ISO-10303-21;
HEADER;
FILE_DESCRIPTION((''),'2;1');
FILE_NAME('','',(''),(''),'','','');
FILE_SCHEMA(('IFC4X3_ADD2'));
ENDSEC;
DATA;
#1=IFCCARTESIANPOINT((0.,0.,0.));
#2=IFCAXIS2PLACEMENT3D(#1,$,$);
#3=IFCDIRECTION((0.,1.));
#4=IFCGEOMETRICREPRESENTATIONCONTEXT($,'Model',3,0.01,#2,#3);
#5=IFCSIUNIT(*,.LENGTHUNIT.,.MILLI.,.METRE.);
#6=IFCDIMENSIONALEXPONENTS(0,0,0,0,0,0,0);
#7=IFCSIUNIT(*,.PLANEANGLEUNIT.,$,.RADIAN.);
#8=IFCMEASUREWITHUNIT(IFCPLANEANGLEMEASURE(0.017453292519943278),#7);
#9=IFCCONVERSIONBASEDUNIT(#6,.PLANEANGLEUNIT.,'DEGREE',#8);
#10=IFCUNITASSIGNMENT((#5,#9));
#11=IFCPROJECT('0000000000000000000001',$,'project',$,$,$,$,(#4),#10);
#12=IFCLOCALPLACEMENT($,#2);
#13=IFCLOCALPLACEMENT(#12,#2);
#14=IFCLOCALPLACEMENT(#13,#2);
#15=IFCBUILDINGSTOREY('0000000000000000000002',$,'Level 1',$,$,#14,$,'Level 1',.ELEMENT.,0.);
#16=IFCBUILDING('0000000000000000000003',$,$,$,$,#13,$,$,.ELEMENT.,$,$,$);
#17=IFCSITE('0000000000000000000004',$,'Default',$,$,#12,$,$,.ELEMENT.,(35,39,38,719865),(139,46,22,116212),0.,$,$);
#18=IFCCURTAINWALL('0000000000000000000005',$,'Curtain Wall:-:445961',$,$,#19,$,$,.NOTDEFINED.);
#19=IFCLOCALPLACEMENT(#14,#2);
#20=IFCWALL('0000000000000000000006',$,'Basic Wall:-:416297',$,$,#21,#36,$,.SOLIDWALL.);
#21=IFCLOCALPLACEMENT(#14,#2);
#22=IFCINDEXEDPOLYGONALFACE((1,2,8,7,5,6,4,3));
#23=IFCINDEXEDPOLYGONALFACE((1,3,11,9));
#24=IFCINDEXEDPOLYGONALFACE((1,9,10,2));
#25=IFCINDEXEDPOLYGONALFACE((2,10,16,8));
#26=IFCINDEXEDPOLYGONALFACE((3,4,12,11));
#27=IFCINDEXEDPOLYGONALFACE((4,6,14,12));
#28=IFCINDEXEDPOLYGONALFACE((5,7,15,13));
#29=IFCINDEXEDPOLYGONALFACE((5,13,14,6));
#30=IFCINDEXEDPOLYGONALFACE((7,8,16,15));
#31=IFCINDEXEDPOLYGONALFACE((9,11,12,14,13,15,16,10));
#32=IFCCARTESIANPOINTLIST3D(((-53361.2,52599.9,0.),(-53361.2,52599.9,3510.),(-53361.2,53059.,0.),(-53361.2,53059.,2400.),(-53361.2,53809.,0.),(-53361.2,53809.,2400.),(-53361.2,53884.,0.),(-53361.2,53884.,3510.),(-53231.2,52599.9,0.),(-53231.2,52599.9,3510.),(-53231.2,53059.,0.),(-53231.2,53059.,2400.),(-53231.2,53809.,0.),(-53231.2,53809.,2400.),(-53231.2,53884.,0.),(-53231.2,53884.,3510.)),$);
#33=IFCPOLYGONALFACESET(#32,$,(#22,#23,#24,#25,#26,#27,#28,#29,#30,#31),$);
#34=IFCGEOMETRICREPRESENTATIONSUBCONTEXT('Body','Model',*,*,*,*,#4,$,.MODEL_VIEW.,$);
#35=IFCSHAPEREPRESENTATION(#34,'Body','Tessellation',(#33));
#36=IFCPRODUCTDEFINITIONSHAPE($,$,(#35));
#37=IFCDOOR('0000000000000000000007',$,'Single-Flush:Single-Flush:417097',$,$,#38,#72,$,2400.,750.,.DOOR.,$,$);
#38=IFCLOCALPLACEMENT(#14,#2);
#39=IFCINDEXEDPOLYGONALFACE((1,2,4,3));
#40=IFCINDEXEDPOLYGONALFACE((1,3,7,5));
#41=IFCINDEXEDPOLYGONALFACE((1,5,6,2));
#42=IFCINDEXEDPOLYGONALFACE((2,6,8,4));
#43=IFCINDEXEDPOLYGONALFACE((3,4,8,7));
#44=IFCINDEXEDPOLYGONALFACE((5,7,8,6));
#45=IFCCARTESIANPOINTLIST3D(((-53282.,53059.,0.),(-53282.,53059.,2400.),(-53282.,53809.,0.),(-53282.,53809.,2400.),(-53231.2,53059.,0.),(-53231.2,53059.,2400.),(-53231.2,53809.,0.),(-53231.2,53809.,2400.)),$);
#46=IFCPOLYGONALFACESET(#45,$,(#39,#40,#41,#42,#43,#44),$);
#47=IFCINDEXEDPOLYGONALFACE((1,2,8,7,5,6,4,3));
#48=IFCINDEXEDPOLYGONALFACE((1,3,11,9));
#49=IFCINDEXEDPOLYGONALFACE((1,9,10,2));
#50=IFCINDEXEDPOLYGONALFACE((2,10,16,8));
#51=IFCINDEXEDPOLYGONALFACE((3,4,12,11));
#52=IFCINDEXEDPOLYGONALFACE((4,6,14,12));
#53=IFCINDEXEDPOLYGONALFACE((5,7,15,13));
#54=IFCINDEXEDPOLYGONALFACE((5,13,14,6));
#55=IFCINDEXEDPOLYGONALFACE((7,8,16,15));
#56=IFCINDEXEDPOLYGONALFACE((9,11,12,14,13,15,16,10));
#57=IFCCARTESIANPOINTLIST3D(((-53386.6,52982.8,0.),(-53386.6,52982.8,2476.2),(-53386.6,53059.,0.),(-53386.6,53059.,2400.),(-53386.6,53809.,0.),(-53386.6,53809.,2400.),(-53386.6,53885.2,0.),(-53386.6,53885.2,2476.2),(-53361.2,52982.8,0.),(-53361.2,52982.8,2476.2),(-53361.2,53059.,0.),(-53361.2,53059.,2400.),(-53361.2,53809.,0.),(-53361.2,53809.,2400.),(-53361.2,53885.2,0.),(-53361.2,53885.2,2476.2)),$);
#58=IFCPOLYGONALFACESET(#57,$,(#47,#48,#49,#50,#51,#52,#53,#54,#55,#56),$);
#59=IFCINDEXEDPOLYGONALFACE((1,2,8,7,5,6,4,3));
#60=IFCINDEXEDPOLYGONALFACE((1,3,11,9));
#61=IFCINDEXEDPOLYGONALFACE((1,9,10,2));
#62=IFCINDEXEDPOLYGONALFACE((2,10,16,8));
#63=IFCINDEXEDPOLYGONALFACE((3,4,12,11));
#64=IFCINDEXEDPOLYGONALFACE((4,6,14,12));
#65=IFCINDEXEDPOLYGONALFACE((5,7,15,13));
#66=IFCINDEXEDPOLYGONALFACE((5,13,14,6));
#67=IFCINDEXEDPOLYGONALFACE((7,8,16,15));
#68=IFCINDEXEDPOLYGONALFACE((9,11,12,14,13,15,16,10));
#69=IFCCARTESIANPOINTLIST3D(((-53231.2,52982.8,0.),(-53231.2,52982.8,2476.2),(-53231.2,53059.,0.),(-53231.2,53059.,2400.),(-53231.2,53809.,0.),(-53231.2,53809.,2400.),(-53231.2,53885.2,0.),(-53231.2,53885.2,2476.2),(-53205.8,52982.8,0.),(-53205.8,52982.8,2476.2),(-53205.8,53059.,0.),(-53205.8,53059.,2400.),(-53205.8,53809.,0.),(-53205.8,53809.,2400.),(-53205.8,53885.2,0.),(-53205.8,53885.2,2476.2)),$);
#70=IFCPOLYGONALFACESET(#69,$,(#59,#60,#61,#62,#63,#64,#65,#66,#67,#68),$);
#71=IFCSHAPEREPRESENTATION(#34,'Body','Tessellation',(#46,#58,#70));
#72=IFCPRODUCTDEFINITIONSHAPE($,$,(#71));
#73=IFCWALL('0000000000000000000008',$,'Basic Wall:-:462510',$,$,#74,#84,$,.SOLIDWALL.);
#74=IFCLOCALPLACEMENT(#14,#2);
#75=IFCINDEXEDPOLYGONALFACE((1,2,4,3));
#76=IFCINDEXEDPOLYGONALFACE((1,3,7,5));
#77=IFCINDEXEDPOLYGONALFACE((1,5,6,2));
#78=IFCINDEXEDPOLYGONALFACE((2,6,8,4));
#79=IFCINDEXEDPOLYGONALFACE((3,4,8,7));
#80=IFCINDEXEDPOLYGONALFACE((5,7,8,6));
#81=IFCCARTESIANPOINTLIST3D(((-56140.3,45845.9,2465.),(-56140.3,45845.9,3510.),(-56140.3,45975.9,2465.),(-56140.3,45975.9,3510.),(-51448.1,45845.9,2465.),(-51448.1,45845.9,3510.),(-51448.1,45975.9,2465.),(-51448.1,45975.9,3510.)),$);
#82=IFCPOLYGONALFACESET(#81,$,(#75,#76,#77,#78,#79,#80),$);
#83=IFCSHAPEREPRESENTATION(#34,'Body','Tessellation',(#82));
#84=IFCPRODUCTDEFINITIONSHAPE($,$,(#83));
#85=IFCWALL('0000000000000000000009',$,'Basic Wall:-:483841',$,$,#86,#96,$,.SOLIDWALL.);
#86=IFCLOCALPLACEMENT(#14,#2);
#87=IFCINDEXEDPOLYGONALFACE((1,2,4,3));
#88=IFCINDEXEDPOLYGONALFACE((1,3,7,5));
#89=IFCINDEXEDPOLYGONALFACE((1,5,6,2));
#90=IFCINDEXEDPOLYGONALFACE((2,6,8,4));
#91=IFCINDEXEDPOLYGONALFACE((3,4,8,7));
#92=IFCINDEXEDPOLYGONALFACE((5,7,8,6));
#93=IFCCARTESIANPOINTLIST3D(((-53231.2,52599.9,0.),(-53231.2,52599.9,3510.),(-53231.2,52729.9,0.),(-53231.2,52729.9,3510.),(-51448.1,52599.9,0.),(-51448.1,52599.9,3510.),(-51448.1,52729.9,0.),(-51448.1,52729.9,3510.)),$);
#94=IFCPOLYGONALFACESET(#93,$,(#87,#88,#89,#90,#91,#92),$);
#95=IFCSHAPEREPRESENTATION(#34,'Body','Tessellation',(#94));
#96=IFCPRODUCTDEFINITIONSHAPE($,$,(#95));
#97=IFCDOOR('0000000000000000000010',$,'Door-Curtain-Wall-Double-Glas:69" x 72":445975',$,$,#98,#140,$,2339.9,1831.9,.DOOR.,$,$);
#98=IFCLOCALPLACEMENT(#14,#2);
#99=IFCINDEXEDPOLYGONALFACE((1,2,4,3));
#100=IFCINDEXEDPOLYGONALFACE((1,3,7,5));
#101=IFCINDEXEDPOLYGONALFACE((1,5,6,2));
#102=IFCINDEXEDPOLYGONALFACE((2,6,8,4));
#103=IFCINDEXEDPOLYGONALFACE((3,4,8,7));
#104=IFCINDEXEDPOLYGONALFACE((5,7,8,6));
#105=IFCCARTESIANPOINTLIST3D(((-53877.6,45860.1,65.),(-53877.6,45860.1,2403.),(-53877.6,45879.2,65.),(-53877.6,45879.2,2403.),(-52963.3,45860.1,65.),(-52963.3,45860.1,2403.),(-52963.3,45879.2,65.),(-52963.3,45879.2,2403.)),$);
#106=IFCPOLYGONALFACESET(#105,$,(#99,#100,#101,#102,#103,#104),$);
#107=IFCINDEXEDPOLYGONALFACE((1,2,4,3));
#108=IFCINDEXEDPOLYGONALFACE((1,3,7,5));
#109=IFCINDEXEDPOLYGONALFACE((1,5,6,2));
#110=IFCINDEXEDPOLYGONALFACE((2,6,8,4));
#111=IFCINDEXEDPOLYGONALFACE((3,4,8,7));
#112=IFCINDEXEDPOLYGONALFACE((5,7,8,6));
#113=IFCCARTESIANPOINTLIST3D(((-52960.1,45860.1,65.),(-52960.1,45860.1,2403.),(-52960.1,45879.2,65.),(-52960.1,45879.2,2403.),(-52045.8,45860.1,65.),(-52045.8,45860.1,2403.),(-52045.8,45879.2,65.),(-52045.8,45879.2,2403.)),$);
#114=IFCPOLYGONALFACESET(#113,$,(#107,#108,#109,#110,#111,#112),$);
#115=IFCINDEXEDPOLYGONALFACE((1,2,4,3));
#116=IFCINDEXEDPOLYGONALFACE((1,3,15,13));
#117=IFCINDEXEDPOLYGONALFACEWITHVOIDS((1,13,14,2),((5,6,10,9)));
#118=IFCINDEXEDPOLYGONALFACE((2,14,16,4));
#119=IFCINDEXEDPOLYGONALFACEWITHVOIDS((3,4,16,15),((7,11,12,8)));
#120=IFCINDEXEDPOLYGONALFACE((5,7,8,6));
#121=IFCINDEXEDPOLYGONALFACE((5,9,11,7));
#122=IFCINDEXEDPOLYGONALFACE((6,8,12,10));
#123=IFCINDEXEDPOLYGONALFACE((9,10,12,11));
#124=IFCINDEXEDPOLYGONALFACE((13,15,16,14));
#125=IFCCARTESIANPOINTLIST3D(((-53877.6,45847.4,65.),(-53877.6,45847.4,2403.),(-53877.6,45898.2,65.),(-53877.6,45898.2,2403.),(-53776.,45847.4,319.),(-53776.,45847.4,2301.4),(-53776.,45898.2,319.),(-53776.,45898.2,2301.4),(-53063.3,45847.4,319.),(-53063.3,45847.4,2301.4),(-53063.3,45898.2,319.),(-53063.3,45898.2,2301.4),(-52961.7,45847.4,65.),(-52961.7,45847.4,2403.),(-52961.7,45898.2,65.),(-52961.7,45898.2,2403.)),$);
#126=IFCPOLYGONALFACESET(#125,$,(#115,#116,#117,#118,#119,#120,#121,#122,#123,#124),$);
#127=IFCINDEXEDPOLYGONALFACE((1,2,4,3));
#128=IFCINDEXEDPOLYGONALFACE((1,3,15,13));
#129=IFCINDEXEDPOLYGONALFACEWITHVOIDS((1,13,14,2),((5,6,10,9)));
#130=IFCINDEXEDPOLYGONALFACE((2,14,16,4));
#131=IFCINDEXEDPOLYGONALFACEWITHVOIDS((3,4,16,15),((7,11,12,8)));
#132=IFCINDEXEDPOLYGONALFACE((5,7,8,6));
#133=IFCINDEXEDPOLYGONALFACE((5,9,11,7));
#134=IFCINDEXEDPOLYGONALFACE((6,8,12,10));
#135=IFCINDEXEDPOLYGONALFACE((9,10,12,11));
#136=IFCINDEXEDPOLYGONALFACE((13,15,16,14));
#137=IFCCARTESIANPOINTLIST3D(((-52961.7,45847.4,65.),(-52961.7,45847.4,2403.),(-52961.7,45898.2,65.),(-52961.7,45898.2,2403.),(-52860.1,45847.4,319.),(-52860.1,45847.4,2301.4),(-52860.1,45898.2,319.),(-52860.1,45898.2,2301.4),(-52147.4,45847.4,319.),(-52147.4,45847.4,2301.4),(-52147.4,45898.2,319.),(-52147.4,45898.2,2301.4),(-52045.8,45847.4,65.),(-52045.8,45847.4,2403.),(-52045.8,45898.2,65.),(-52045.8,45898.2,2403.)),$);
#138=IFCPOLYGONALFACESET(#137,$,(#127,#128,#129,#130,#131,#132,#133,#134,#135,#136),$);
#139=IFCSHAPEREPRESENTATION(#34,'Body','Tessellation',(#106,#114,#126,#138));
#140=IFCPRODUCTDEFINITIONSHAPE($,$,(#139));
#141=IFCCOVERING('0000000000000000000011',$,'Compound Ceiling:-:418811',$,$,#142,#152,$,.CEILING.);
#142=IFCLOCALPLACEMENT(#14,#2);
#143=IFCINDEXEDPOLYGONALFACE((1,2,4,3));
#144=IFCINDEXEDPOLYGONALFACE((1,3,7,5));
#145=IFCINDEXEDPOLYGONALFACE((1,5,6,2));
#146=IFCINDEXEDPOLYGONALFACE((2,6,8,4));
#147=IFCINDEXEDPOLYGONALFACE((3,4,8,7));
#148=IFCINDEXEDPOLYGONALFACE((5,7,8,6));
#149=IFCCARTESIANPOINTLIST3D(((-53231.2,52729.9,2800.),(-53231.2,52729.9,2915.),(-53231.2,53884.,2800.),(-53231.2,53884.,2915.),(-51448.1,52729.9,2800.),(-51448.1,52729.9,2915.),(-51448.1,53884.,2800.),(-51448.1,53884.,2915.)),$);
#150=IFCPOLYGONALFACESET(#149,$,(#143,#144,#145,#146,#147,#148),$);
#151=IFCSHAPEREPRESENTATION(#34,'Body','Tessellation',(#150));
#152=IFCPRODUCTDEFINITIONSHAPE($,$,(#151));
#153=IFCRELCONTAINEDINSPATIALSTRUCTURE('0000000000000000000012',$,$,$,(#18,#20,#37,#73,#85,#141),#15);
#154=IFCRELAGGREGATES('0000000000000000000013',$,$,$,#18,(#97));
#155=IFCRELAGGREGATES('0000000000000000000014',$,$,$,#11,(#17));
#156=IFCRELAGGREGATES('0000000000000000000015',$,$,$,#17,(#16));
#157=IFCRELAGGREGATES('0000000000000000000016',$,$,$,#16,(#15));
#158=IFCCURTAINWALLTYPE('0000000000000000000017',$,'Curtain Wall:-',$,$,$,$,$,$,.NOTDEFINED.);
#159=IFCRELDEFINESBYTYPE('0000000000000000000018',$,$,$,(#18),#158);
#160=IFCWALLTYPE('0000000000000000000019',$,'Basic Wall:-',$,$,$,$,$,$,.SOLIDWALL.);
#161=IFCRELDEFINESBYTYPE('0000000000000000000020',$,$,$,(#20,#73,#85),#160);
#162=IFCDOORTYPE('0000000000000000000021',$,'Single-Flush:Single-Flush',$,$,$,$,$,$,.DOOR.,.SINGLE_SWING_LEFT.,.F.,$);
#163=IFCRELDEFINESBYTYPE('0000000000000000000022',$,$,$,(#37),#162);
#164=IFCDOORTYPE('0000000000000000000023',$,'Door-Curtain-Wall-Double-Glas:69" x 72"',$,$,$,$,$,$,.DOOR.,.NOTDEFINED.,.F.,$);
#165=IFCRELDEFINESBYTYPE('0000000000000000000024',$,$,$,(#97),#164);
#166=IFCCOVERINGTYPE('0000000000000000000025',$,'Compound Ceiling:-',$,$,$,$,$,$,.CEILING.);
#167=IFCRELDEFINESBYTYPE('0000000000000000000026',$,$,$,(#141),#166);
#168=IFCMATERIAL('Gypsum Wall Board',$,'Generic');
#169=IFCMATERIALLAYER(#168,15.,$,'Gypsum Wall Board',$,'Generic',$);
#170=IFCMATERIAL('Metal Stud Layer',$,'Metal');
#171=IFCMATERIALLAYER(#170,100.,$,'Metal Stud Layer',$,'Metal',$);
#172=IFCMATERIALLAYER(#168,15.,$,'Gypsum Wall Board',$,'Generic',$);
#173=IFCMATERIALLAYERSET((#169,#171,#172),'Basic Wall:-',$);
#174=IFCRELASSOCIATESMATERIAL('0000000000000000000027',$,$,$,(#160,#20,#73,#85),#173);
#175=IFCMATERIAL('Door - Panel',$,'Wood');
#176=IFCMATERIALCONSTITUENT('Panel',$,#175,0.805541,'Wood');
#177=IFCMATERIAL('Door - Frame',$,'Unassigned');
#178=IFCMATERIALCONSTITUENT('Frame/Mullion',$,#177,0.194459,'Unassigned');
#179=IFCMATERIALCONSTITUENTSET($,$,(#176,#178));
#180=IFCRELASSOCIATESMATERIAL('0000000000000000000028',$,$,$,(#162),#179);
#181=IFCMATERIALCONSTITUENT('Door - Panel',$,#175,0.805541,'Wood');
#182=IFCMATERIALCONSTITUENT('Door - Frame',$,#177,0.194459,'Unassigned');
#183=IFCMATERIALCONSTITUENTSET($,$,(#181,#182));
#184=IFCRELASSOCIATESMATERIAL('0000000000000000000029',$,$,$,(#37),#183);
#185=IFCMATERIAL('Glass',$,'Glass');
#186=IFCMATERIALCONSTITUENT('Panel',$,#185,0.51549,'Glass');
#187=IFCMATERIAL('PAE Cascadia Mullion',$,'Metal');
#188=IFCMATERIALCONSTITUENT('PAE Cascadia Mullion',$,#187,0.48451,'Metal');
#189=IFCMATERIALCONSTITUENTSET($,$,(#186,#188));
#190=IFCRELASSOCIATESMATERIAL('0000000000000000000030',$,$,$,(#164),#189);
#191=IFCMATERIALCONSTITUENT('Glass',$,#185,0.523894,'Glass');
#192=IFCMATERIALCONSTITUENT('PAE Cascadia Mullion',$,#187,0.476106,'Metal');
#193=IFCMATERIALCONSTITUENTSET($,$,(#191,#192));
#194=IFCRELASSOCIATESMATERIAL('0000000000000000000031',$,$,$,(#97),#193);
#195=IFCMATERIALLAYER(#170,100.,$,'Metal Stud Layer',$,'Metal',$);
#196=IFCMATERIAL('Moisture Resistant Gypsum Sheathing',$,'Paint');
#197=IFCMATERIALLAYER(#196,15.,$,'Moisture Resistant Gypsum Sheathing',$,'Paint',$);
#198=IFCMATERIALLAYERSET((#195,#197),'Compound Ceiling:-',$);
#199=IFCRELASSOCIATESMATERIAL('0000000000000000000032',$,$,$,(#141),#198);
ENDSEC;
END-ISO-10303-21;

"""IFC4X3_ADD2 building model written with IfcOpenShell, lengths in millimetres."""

from ifc_helpers import new_model, entity, si_unit, converted_unit, direction, frame, frame_2d, origin, place, context, subcontext, project, spatial, polyline, rectangle, outline, extrude, source, transform, mapped, material, layer, layer_set, layer_usage, constituent, constituent_set, type_object, type_shapes, element, fill, aggregate, save


model = new_model("IFC4X3_ADD2")

# Units and contexts
model_context = context("Model", 3, precision=0.01, world=origin(), true_north=direction((0.0, 1.0)))
body_context = subcontext(model_context, "Body", "Model", "MODEL_VIEW")
ifc_project = project(units=[si_unit("LENGTHUNIT", "METRE", prefix="MILLI"), converted_unit("PLANEANGLEUNIT", "DEGREE", entity("IfcPlaneAngleMeasure", 0.017453292519943278), si_unit("PLANEANGLEUNIT", "RADIAN"), dimensions=[0, 0, 0, 0, 0, 0, 0])], contexts=[model_context])

# Site, building, storey
site_placement = place(None, origin())
site = spatial("IfcSite", under=ifc_project, at=site_placement, Name="Default", CompositionType="ELEMENT", RefLatitude=(35, 39, 38, 719865), RefLongitude=(139, 46, 22, 116212), RefElevation=0.0)
building_placement = place(site_placement, origin())
building = spatial("IfcBuilding", under=site, at=building_placement, CompositionType="ELEMENT")
storey_placement = place(building_placement, origin())
storey = spatial("IfcBuildingStorey", under=building, at=storey_placement, Name="Level 1", LongName="Level 1", CompositionType="ELEMENT", Elevation=0.0)

# Curtain wall
curtain_wall_type = type_object("IfcCurtainWallType", Name="Curtain Wall:-", PredefinedType="NOTDEFINED")
curtain_wall_placement = place(storey_placement, origin())
curtain_wall = element("IfcCurtainWall", 1, at=curtain_wall_placement, inside=storey, type_object=curtain_wall_type, Name="Curtain Wall:-:445961", PredefinedType="NOTDEFINED")

# Shared definitions
ifc_material_1 = material(Name="Glass", Category="Glass")

# Shared definitions
ifc_material_2 = material(Name="Gypsum Wall Board", Category="Generic")
ifc_layer_1 = layer(ifc_material_2, 15.0, Name="Gypsum Wall Board", Category="Generic")
ifc_material_3 = material(Name="Metal Stud Layer", Category="Metal")
ifc_layer_2 = layer(ifc_material_3, 100.0, Name="Metal Stud Layer", Category="Metal")
ifc_layer_3 = layer(ifc_material_2, 15.0, Name="Gypsum Wall Board", Category="Generic")
ifc_layer_set_1 = layer_set([ifc_layer_1, ifc_layer_2, ifc_layer_3], Name="Basic Wall:-")
wall_type = type_object("IfcWallType", Name="Basic Wall:-", PredefinedType="SOLIDWALL", material=ifc_layer_set_1)

# Wall, opening, door
wall_1_placement = place(storey_placement, frame((-53296.2, 52599.9, 0.0), z_axis=(0.0, 0.0, 1.0), x_axis=(0.0, 1.0, 0.0)))
wall_1 = element("IfcWall", 2, at=wall_1_placement, inside=storey, type_object=wall_type, material=ifc_layer_set_1, Name="Basic Wall:-:416297", PredefinedType="SOLIDWALL", context=body_context, shape_type="SweptSolid", body=[
    extrude(rectangle(XDim=1284.2, YDim=130.0, at=frame_2d((642.1, 0.0), x_axis=(-1.0, 0.0))), origin(), (0.0, 0.0, 1.0), 3510.0),
])
opening_1_placement = place(wall_1_placement, frame((1209.1, 65.0, 0.0)))
opening_1 = element("IfcOpeningElement", 3, at=opening_1_placement, cuts=wall_1, PredefinedType="OPENING", context=body_context, shape_type="SweptSolid", body=[
    extrude(rectangle(XDim=750.0, YDim=2400.0, at=frame_2d((1200.0, 375.0), x_axis=(0.0, -1.0))), frame((0.0, 0.0, 0.0), z_axis=(0.0, -1.0, 0.0), x_axis=(0.0, 0.0, 1.0)), (0.0, 0.0, 1.0), 130.0),
])
ifc_material_4 = material(Name="Door - Panel", Category="Wood")
ifc_constituent_1 = constituent(ifc_material_4, Name="Door - Panel", Category="Wood", fraction=0.805541)
ifc_material_5 = material(Name="Door - Frame", Category="Unassigned")
ifc_constituent_2 = constituent(ifc_material_5, Name="Door - Frame", Category="Unassigned", fraction=0.194459)
ifc_constituent_set_1 = constituent_set(constituents=[ifc_constituent_1, ifc_constituent_2])
ifc_constituent_3 = constituent(ifc_material_4, Name="Panel", Category="Wood", fraction=0.805541)
ifc_constituent_4 = constituent(ifc_material_5, Name="Frame/Mullion", Category="Unassigned", fraction=0.194459)
ifc_constituent_set_2 = constituent_set(constituents=[ifc_constituent_3, ifc_constituent_4])
door_type_1 = type_object("IfcDoorType", Name="Single-Flush:Single-Flush", OperationType="SINGLE_SWING_LEFT", ParameterTakesPrecedence=False, PredefinedType="DOOR", material=ifc_constituent_set_2)
shared_shape_1 = source(origin(), body_context, "Body", "SweptSolid", [
    extrude(rectangle(XDim=750.0, YDim=50.8, at=frame_2d((0.0, 0.0), x_axis=(1.0, 0.0))), frame((375.0, 104.6, 0.0)), (0.0, 0.0, 1.0), 2400.0),
    extrude(outline(polyline([(-1257.1, -451.2), (1219.0, -451.2), (1219.0, -375.0), (-1180.9, -375.0), (-1180.9, 375.0), (1219.0, 375.0), (1219.0, 451.2), (-1257.1, 451.2), (-1257.1, -451.2)])), frame((375.0, 0.0, 1219.0), z_axis=(0.0, -1.0, 0.0), x_axis=(0.0, 0.0, -1.0)), (0.0, 0.0, 1.0), 25.4),
    extrude(outline(polyline([(-451.2, -1257.1), (451.2, -1257.1), (451.2, 1219.1), (375.0, 1219.1), (375.0, -1181.0), (-375.0, -1181.0), (-375.0, 1219.1), (-451.2, 1219.1), (-451.2, -1257.1)])), frame((375.0, 155.4, 1219.1), z_axis=(0.0, -1.0, 0.0), x_axis=(-1.0, 0.0, 0.0)), (0.0, 0.0, 1.0), 25.4),
])
type_shapes(door_type_1, [shared_shape_1])
door_1_placement = place(opening_1_placement, frame((0.0, 0.0, 0.0), z_axis=(0.0, 0.0, 1.0), x_axis=(-1.0, 0.0, 0.0)))
door_1 = element("IfcDoor", 4, at=door_1_placement, inside=storey, type_object=door_type_1, material=ifc_constituent_set_1, Name="Single-Flush:Single-Flush:417097", OverallHeight=2400.0, OverallWidth=750.0, PredefinedType="DOOR", context=body_context, shape_type="MappedRepresentation", body=[
    mapped(shared_shape_1, transform((0.0, 0.0, 0.0), scale=1.0)),
])
fill(opening_1, door_1)

# Walls
wall_2_placement = place(storey_placement, frame((-51448.1, 45910.9, 2465.0), z_axis=(0.0, 0.0, 1.0), x_axis=(-1.0, 0.0, 0.0)))
element("IfcWall", 5, at=wall_2_placement, inside=storey, type_object=wall_type, material=ifc_layer_set_1, Name="Basic Wall:-:462510", PredefinedType="SOLIDWALL", context=body_context, shape_type="SweptSolid", body=[
    extrude(rectangle(XDim=4692.1, YDim=130.0, at=frame_2d((2346.1, 0.0), x_axis=(-1.0, 0.0))), origin(), (0.0, 0.0, 1.0), 1045.0),
])
wall_3_placement = place(storey_placement, frame((-51448.1, 52664.9, 0.0), z_axis=(0.0, 0.0, 1.0), x_axis=(-1.0, 0.0, 0.0)))
element("IfcWall", 6, at=wall_3_placement, inside=storey, type_object=wall_type, material=ifc_layer_set_1, Name="Basic Wall:-:483841", PredefinedType="SOLIDWALL", context=body_context, shape_type="SweptSolid", body=[
    extrude(rectangle(XDim=1783.1, YDim=130.0, at=frame_2d((891.5, 0.0), x_axis=(-1.0, 0.0))), origin(), (0.0, 0.0, 1.0), 3510.0),
])

# Door
ifc_constituent_5 = constituent(ifc_material_1, Name="Glass", Category="Glass", fraction=0.523894)
ifc_material_6 = material(Name="PAE Cascadia Mullion", Category="Metal")
ifc_constituent_6 = constituent(ifc_material_6, Name="PAE Cascadia Mullion", Category="Metal", fraction=0.476106)
ifc_constituent_set_3 = constituent_set(constituents=[ifc_constituent_5, ifc_constituent_6])
ifc_constituent_7 = constituent(ifc_material_1, Name="Panel", Category="Glass", fraction=0.51549)
ifc_constituent_8 = constituent(ifc_material_6, Name="PAE Cascadia Mullion", Category="Metal", fraction=0.48451)
ifc_constituent_set_4 = constituent_set(constituents=[ifc_constituent_7, ifc_constituent_8])
door_type_2 = type_object("IfcDoorType", Name="Door-Curtain-Wall-Double-Glas:69\" x 72\"", OperationType="NOTDEFINED", ParameterTakesPrecedence=False, PredefinedType="DOOR", material=ifc_constituent_set_4)
shared_shape_2 = source(origin(), body_context, "Body", "SweptSolid", [
    extrude(rectangle(XDim=19.1, YDim=914.4, at=frame_2d((0.0, 0.0), x_axis=(1.0, 0.0))), frame((458.7, 41.3, 0.0), z_axis=(0.0, 0.0, 1.0), x_axis=(0.0, 1.0, 0.0)), (0.0, 0.0, 1.0), 2338.0),
    extrude(rectangle(XDim=19.1, YDim=914.3, at=frame_2d((0.0, 0.0), x_axis=(1.0, 0.0))), frame((-458.8, 41.3, 0.0), z_axis=(0.0, 0.0, 1.0), x_axis=(0.0, 1.0, 0.0)), (0.0, 0.0, 1.0), 2338.0),
    extrude(outline(polyline([(-458.0, -1169.0), (458.0, -1169.0), (458.0, 1169.0), (-458.0, 1169.0), (-458.0, -1169.0)]), holes=[polyline([(-356.4, -1067.4), (-356.4, 915.0), (356.4, 915.0), (356.4, -1067.4), (-356.4, -1067.4)])]), frame((458.0, 12.7, 1169.0), z_axis=(0.0, 1.0, 0.0), x_axis=(1.0, 0.0, 0.0)), (0.0, 0.0, 1.0), 50.8),
    extrude(outline(polyline([(-1169.0, -458.0), (1169.0, -458.0), (1169.0, 458.0), (-1169.0, 458.0), (-1169.0, -458.0)]), holes=[polyline([(-1067.4, -356.4), (-1067.4, 356.4), (915.0, 356.4), (915.0, -356.4), (-1067.4, -356.4)])]), frame((-458.0, 12.7, 1169.0), z_axis=(0.0, 1.0, 0.0), x_axis=(0.0, 0.0, -1.0)), (0.0, 0.0, 1.0), 50.8),
])
type_shapes(door_type_2, [shared_shape_2])
door_2_placement = place(curtain_wall_placement, frame((-52961.7, 45910.9, 65.0), z_axis=(0.0, 0.0, 1.0), x_axis=(-1.0, 0.0, 0.0)))
door_2 = element("IfcDoor", 7, at=door_2_placement, type_object=door_type_2, material=ifc_constituent_set_3, Name="Door-Curtain-Wall-Double-Glas:69\" x 72\":445975", OverallHeight=2339.9, OverallWidth=1831.9, PredefinedType="DOOR", context=body_context, shape_type="MappedRepresentation", body=[
    mapped(shared_shape_2, transform((0.0, 0.0, 0.0), scale=1.0)),
])
aggregate(curtain_wall, [door_2])

# Covering
ifc_layer_4 = layer(ifc_material_3, 100.0, Name="Metal Stud Layer", Category="Metal")
ifc_material_7 = material(Name="Moisture Resistant Gypsum Sheathing", Category="Paint")
ifc_layer_5 = layer(ifc_material_7, 15.0, Name="Moisture Resistant Gypsum Sheathing", Category="Paint")
ifc_layer_set_2 = layer_set([ifc_layer_4, ifc_layer_5], Name="Compound Ceiling:-")
ifc_layer_usage_1 = layer_usage(ifc_layer_set_2, "AXIS3", "NEGATIVE", 0.0)
covering_type = type_object("IfcCoveringType", Name="Compound Ceiling:-", PredefinedType="CEILING")
covering_placement = place(storey_placement, frame((-53231.2, 52729.9, 2800.0)))
element("IfcCovering", 8, at=covering_placement, inside=storey, type_object=covering_type, material=ifc_layer_usage_1, Name="Compound Ceiling:-:418811", PredefinedType="CEILING", context=body_context, shape_type="SweptSolid", body=[
    extrude(rectangle(XDim=1154.2, YDim=1783.1, at=frame_2d((0.0, 0.0), x_axis=(1.0, 0.0))), frame((891.5, 577.1, 0.0), z_axis=(0.0, 0.0, 1.0), x_axis=(0.0, -1.0, 0.0)), (0.0, 0.0, 1.0), 115.0),
])

save(model, "model.ifc")
